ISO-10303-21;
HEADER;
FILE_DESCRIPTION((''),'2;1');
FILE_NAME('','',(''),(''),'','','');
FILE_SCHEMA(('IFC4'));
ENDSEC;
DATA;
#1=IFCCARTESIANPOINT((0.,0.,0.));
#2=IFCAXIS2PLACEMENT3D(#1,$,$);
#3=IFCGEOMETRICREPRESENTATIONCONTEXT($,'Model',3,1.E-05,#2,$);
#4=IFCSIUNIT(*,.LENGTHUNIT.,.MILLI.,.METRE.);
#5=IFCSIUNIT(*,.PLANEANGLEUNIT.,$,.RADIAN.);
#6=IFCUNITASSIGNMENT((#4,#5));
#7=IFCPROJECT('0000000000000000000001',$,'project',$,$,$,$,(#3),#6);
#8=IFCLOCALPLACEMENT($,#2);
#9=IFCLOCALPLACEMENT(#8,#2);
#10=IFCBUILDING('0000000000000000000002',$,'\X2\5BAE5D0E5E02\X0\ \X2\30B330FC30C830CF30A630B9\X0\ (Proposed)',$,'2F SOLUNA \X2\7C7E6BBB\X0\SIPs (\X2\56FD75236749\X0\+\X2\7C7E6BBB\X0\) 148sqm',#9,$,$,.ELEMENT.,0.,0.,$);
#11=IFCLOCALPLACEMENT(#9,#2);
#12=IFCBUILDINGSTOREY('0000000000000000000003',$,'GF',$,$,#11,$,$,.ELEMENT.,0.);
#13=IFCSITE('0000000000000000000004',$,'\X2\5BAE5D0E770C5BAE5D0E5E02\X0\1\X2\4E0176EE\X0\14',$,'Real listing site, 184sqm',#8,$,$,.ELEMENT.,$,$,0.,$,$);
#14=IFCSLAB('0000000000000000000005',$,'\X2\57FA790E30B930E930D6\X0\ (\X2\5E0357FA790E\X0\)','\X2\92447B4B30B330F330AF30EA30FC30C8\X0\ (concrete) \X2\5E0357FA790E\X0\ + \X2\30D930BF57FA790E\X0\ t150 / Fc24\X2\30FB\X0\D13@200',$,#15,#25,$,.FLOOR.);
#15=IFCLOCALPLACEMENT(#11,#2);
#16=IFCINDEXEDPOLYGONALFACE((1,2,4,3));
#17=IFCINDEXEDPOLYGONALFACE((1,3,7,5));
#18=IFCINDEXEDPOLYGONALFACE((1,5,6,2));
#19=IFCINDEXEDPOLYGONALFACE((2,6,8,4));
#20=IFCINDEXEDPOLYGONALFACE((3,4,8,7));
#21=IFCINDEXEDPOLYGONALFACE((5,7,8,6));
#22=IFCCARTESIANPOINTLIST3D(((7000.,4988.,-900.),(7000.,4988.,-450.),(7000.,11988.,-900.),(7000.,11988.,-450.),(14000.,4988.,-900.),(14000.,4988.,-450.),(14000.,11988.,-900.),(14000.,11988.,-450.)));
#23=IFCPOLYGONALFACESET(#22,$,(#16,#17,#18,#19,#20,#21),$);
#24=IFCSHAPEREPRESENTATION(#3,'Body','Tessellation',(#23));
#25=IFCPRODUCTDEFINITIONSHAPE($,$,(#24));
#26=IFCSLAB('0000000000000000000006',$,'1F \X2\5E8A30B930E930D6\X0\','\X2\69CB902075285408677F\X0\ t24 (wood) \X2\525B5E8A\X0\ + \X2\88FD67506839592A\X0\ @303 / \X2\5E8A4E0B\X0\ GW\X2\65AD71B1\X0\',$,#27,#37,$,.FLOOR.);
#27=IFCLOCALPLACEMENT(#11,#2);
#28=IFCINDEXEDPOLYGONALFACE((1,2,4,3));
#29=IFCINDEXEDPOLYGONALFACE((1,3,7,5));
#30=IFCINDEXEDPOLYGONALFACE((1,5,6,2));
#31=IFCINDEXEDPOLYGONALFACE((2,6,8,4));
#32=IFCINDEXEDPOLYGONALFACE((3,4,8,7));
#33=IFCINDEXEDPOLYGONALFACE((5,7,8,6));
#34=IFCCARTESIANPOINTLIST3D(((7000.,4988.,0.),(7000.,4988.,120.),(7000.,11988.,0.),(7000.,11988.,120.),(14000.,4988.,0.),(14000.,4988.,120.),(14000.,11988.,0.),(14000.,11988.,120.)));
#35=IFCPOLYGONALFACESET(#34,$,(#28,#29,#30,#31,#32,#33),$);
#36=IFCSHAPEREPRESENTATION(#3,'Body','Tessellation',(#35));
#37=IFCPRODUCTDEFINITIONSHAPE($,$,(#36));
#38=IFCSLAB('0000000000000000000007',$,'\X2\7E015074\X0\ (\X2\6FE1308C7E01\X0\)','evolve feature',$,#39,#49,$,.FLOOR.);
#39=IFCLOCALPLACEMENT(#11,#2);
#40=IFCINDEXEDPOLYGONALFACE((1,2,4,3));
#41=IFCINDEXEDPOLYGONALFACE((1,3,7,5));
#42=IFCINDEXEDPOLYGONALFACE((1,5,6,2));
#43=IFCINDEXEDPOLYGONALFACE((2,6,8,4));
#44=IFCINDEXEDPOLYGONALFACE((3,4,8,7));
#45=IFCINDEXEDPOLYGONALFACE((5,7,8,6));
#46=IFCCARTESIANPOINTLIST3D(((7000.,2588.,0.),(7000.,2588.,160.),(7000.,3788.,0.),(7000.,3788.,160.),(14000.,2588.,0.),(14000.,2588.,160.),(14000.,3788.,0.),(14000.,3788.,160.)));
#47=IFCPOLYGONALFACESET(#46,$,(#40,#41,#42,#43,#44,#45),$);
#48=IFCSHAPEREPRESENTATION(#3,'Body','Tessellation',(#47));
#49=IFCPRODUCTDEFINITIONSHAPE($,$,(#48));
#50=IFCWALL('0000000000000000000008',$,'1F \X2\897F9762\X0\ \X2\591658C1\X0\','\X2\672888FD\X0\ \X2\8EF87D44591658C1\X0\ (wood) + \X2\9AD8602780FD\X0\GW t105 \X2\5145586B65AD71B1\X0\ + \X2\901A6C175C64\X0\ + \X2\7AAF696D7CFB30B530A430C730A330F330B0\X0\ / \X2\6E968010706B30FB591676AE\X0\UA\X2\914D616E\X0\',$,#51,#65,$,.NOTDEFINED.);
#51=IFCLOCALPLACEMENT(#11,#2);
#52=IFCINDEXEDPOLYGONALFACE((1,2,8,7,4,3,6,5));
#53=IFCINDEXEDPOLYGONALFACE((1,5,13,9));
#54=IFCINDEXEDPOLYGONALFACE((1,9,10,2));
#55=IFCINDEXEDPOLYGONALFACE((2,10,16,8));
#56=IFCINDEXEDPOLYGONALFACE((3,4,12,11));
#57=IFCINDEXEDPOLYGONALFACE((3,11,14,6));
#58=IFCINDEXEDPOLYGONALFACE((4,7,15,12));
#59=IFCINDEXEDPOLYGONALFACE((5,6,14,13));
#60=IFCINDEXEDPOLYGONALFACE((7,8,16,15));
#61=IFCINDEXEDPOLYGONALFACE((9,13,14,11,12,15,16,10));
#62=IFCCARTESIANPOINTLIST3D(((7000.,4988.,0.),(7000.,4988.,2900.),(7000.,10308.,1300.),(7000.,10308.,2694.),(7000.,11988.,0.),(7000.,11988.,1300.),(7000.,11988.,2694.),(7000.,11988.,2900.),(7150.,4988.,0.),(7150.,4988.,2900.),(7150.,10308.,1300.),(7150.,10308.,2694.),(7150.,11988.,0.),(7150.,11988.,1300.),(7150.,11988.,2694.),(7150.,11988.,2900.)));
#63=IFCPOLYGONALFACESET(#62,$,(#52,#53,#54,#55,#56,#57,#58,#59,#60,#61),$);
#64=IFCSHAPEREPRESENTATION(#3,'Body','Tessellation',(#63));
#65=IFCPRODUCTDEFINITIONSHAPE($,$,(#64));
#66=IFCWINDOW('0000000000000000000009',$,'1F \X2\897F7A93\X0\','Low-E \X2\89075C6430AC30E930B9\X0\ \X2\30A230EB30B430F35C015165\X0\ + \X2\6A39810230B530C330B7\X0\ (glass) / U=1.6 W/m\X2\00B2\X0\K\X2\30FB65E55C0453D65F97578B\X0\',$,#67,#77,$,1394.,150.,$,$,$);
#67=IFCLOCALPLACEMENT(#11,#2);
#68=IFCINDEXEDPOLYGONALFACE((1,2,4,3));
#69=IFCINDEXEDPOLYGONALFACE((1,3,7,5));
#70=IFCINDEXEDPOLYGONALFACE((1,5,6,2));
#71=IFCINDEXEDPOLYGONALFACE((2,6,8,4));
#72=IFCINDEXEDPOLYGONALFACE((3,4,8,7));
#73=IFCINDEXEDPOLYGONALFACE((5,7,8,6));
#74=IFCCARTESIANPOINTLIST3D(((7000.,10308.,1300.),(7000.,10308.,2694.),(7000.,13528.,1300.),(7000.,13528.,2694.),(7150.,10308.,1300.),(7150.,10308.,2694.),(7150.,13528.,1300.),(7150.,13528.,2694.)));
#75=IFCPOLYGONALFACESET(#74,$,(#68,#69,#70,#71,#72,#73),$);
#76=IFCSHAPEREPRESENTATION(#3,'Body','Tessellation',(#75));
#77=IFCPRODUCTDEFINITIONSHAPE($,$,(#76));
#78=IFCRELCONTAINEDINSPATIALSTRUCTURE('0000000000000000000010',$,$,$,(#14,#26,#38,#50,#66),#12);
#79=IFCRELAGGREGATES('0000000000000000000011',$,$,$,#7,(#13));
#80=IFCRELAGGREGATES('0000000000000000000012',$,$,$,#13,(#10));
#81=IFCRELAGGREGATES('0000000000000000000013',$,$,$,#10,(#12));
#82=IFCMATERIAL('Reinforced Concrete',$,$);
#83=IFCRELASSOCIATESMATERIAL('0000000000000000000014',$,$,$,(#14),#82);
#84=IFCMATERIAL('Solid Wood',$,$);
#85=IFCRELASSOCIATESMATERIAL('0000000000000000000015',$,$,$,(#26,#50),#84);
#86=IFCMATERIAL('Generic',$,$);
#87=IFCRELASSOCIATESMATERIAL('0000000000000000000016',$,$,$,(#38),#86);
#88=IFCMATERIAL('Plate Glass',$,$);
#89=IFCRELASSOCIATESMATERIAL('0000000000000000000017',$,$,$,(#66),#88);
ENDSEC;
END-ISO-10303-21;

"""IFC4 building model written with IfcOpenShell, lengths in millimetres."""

from ifc_helpers import new_model, si_unit, frame, frame_2d, origin, place, context, project, spatial, rectangle, extrude, material, element, fill, save


model = new_model("IFC4")

# Units and contexts
model_context = context("Model", 3, precision=1e-05, world=origin())
ifc_project = project(units=[si_unit("LENGTHUNIT", "METRE", prefix="MILLI"), si_unit("PLANEANGLEUNIT", "RADIAN")], contexts=[model_context])

# Site, building, storey
site_placement = place(None, origin())
site = spatial("IfcSite", under=ifc_project, at=site_placement, Name="宮崎県宮崎市1丁目14", ObjectType="Real listing site, 184sqm", CompositionType="ELEMENT", RefElevation=0.0)
building_placement = place(site_placement, origin())
building = spatial("IfcBuilding", under=site, at=building_placement, Name="宮崎市 コートハウス (Proposed)", ObjectType="2F SOLUNA 籾殻SIPs (国産杉+籾殻) 148sqm", CompositionType="ELEMENT", ElevationOfRefHeight=0.0, ElevationOfTerrain=0.0)
storey_placement = place(building_placement, origin())
storey = spatial("IfcBuildingStorey", under=building, at=storey_placement, Name="GF", CompositionType="ELEMENT", Elevation=0.0)

# Slabs
ifc_material_1 = material(Name="Reinforced Concrete")
slab_1_placement = place(storey_placement, frame((3500.0, 2494.0, -450.0)))
element("IfcSlab", 1, at=slab_1_placement, inside=storey, material=ifc_material_1, Name="基礎スラブ (布基礎)", Description="鉄筋コンクリート (concrete) 布基礎 + ベタ基礎 t150 / Fc24・D13@200", PredefinedType="FLOOR", context=model_context, shape_type="SweptSolid", body=[
    extrude(rectangle(XDim=7000.0, YDim=7000.0, at=frame_2d((3500.0, 3500.0))), frame((3500.0, 2494.0, -450.0)), (0.0, 0.0, 1.0), 450.0),
])
ifc_material_2 = material(Name="Solid Wood")
slab_2_placement = place(storey_placement, frame((3500.0, 2494.0, 0.0)))
element("IfcSlab", 2, at=slab_2_placement, inside=storey, material=ifc_material_2, Name="1F 床スラブ", Description="構造用合板 t24 (wood) 剛床 + 製材根太 @303 / 床下 GW断熱", PredefinedType="FLOOR", context=model_context, shape_type="SweptSolid", body=[
    extrude(rectangle(XDim=7000.0, YDim=7000.0, at=frame_2d((3500.0, 3500.0))), frame((3500.0, 2494.0, 0.0)), (0.0, 0.0, 1.0), 120.0),
])
ifc_material_3 = material(Name="Generic")
slab_3_placement = place(storey_placement, frame((3500.0, 1294.0, 0.0)))
element("IfcSlab", 3, at=slab_3_placement, inside=storey, material=ifc_material_3, Name="縁側 (濡れ縁)", Description="evolve feature", PredefinedType="FLOOR", context=model_context, shape_type="SweptSolid", body=[
    extrude(rectangle(XDim=7000.0, YDim=1200.0, at=frame_2d((3500.0, 600.0))), frame((3500.0, 1294.0, 0.0)), (0.0, 0.0, 1.0), 160.0),
])

# Shared definitions
ifc_material_4 = material(Name="Plate Glass")

# Wall, opening, window
wall_1_placement = place(storey_placement, frame((3500.0, 2494.0, 0.0)))
wall_1 = element("IfcWall", 4, at=wall_1_placement, inside=storey, material=ifc_material_2, Name="1F 西面 外壁", Description="木製 軸組外壁 (wood) + 高性能GW t105 充填断熱 + 通気層 + 窯業系サイディング / 準耐火・外皮UA配慮", PredefinedType="NOTDEFINED", context=model_context, shape_type="SweptSolid", body=[
    extrude(rectangle(XDim=150.0, YDim=7000.0, at=frame_2d((75.0, 3500.0))), frame((3500.0, 2494.0, 0.0)), (0.0, 0.0, 1.0), 2900.0),
])
opening_1_placement = place(storey_placement, frame((3500.0, 5154.0, 650.0)))
opening_1 = element("IfcOpeningElement", 5, at=opening_1_placement, cuts=wall_1, PredefinedType="NOTDEFINED", context=model_context, shape_type="SweptSolid", body=[
    extrude(rectangle(XDim=150.0, YDim=3220.0, at=frame_2d((75.0, 1610.0))), frame((3500.0, 5154.0, 650.0)), (0.0, 0.0, 1.0), 1394.0),
])
window_1_placement = place(storey_placement, frame((3500.0, 5154.0, 650.0)))
window_1 = element("IfcWindow", 6, at=window_1_placement, inside=storey, material=ifc_material_4, Name="1F 西窓", Description="Low-E 複層ガラス アルゴン封入 + 樹脂サッシ (glass) / U=1.6 W/m²K・日射取得型", OverallHeight=1394.0, OverallWidth=150.0, context=model_context, shape_type="SweptSolid", body=[
    extrude(rectangle(XDim=150.0, YDim=3220.0, at=frame_2d((75.0, 1610.0))), frame((3500.0, 5154.0, 650.0)), (0.0, 0.0, 1.0), 1394.0),
])
fill(opening_1, window_1)

save(model, "model.ifc")
